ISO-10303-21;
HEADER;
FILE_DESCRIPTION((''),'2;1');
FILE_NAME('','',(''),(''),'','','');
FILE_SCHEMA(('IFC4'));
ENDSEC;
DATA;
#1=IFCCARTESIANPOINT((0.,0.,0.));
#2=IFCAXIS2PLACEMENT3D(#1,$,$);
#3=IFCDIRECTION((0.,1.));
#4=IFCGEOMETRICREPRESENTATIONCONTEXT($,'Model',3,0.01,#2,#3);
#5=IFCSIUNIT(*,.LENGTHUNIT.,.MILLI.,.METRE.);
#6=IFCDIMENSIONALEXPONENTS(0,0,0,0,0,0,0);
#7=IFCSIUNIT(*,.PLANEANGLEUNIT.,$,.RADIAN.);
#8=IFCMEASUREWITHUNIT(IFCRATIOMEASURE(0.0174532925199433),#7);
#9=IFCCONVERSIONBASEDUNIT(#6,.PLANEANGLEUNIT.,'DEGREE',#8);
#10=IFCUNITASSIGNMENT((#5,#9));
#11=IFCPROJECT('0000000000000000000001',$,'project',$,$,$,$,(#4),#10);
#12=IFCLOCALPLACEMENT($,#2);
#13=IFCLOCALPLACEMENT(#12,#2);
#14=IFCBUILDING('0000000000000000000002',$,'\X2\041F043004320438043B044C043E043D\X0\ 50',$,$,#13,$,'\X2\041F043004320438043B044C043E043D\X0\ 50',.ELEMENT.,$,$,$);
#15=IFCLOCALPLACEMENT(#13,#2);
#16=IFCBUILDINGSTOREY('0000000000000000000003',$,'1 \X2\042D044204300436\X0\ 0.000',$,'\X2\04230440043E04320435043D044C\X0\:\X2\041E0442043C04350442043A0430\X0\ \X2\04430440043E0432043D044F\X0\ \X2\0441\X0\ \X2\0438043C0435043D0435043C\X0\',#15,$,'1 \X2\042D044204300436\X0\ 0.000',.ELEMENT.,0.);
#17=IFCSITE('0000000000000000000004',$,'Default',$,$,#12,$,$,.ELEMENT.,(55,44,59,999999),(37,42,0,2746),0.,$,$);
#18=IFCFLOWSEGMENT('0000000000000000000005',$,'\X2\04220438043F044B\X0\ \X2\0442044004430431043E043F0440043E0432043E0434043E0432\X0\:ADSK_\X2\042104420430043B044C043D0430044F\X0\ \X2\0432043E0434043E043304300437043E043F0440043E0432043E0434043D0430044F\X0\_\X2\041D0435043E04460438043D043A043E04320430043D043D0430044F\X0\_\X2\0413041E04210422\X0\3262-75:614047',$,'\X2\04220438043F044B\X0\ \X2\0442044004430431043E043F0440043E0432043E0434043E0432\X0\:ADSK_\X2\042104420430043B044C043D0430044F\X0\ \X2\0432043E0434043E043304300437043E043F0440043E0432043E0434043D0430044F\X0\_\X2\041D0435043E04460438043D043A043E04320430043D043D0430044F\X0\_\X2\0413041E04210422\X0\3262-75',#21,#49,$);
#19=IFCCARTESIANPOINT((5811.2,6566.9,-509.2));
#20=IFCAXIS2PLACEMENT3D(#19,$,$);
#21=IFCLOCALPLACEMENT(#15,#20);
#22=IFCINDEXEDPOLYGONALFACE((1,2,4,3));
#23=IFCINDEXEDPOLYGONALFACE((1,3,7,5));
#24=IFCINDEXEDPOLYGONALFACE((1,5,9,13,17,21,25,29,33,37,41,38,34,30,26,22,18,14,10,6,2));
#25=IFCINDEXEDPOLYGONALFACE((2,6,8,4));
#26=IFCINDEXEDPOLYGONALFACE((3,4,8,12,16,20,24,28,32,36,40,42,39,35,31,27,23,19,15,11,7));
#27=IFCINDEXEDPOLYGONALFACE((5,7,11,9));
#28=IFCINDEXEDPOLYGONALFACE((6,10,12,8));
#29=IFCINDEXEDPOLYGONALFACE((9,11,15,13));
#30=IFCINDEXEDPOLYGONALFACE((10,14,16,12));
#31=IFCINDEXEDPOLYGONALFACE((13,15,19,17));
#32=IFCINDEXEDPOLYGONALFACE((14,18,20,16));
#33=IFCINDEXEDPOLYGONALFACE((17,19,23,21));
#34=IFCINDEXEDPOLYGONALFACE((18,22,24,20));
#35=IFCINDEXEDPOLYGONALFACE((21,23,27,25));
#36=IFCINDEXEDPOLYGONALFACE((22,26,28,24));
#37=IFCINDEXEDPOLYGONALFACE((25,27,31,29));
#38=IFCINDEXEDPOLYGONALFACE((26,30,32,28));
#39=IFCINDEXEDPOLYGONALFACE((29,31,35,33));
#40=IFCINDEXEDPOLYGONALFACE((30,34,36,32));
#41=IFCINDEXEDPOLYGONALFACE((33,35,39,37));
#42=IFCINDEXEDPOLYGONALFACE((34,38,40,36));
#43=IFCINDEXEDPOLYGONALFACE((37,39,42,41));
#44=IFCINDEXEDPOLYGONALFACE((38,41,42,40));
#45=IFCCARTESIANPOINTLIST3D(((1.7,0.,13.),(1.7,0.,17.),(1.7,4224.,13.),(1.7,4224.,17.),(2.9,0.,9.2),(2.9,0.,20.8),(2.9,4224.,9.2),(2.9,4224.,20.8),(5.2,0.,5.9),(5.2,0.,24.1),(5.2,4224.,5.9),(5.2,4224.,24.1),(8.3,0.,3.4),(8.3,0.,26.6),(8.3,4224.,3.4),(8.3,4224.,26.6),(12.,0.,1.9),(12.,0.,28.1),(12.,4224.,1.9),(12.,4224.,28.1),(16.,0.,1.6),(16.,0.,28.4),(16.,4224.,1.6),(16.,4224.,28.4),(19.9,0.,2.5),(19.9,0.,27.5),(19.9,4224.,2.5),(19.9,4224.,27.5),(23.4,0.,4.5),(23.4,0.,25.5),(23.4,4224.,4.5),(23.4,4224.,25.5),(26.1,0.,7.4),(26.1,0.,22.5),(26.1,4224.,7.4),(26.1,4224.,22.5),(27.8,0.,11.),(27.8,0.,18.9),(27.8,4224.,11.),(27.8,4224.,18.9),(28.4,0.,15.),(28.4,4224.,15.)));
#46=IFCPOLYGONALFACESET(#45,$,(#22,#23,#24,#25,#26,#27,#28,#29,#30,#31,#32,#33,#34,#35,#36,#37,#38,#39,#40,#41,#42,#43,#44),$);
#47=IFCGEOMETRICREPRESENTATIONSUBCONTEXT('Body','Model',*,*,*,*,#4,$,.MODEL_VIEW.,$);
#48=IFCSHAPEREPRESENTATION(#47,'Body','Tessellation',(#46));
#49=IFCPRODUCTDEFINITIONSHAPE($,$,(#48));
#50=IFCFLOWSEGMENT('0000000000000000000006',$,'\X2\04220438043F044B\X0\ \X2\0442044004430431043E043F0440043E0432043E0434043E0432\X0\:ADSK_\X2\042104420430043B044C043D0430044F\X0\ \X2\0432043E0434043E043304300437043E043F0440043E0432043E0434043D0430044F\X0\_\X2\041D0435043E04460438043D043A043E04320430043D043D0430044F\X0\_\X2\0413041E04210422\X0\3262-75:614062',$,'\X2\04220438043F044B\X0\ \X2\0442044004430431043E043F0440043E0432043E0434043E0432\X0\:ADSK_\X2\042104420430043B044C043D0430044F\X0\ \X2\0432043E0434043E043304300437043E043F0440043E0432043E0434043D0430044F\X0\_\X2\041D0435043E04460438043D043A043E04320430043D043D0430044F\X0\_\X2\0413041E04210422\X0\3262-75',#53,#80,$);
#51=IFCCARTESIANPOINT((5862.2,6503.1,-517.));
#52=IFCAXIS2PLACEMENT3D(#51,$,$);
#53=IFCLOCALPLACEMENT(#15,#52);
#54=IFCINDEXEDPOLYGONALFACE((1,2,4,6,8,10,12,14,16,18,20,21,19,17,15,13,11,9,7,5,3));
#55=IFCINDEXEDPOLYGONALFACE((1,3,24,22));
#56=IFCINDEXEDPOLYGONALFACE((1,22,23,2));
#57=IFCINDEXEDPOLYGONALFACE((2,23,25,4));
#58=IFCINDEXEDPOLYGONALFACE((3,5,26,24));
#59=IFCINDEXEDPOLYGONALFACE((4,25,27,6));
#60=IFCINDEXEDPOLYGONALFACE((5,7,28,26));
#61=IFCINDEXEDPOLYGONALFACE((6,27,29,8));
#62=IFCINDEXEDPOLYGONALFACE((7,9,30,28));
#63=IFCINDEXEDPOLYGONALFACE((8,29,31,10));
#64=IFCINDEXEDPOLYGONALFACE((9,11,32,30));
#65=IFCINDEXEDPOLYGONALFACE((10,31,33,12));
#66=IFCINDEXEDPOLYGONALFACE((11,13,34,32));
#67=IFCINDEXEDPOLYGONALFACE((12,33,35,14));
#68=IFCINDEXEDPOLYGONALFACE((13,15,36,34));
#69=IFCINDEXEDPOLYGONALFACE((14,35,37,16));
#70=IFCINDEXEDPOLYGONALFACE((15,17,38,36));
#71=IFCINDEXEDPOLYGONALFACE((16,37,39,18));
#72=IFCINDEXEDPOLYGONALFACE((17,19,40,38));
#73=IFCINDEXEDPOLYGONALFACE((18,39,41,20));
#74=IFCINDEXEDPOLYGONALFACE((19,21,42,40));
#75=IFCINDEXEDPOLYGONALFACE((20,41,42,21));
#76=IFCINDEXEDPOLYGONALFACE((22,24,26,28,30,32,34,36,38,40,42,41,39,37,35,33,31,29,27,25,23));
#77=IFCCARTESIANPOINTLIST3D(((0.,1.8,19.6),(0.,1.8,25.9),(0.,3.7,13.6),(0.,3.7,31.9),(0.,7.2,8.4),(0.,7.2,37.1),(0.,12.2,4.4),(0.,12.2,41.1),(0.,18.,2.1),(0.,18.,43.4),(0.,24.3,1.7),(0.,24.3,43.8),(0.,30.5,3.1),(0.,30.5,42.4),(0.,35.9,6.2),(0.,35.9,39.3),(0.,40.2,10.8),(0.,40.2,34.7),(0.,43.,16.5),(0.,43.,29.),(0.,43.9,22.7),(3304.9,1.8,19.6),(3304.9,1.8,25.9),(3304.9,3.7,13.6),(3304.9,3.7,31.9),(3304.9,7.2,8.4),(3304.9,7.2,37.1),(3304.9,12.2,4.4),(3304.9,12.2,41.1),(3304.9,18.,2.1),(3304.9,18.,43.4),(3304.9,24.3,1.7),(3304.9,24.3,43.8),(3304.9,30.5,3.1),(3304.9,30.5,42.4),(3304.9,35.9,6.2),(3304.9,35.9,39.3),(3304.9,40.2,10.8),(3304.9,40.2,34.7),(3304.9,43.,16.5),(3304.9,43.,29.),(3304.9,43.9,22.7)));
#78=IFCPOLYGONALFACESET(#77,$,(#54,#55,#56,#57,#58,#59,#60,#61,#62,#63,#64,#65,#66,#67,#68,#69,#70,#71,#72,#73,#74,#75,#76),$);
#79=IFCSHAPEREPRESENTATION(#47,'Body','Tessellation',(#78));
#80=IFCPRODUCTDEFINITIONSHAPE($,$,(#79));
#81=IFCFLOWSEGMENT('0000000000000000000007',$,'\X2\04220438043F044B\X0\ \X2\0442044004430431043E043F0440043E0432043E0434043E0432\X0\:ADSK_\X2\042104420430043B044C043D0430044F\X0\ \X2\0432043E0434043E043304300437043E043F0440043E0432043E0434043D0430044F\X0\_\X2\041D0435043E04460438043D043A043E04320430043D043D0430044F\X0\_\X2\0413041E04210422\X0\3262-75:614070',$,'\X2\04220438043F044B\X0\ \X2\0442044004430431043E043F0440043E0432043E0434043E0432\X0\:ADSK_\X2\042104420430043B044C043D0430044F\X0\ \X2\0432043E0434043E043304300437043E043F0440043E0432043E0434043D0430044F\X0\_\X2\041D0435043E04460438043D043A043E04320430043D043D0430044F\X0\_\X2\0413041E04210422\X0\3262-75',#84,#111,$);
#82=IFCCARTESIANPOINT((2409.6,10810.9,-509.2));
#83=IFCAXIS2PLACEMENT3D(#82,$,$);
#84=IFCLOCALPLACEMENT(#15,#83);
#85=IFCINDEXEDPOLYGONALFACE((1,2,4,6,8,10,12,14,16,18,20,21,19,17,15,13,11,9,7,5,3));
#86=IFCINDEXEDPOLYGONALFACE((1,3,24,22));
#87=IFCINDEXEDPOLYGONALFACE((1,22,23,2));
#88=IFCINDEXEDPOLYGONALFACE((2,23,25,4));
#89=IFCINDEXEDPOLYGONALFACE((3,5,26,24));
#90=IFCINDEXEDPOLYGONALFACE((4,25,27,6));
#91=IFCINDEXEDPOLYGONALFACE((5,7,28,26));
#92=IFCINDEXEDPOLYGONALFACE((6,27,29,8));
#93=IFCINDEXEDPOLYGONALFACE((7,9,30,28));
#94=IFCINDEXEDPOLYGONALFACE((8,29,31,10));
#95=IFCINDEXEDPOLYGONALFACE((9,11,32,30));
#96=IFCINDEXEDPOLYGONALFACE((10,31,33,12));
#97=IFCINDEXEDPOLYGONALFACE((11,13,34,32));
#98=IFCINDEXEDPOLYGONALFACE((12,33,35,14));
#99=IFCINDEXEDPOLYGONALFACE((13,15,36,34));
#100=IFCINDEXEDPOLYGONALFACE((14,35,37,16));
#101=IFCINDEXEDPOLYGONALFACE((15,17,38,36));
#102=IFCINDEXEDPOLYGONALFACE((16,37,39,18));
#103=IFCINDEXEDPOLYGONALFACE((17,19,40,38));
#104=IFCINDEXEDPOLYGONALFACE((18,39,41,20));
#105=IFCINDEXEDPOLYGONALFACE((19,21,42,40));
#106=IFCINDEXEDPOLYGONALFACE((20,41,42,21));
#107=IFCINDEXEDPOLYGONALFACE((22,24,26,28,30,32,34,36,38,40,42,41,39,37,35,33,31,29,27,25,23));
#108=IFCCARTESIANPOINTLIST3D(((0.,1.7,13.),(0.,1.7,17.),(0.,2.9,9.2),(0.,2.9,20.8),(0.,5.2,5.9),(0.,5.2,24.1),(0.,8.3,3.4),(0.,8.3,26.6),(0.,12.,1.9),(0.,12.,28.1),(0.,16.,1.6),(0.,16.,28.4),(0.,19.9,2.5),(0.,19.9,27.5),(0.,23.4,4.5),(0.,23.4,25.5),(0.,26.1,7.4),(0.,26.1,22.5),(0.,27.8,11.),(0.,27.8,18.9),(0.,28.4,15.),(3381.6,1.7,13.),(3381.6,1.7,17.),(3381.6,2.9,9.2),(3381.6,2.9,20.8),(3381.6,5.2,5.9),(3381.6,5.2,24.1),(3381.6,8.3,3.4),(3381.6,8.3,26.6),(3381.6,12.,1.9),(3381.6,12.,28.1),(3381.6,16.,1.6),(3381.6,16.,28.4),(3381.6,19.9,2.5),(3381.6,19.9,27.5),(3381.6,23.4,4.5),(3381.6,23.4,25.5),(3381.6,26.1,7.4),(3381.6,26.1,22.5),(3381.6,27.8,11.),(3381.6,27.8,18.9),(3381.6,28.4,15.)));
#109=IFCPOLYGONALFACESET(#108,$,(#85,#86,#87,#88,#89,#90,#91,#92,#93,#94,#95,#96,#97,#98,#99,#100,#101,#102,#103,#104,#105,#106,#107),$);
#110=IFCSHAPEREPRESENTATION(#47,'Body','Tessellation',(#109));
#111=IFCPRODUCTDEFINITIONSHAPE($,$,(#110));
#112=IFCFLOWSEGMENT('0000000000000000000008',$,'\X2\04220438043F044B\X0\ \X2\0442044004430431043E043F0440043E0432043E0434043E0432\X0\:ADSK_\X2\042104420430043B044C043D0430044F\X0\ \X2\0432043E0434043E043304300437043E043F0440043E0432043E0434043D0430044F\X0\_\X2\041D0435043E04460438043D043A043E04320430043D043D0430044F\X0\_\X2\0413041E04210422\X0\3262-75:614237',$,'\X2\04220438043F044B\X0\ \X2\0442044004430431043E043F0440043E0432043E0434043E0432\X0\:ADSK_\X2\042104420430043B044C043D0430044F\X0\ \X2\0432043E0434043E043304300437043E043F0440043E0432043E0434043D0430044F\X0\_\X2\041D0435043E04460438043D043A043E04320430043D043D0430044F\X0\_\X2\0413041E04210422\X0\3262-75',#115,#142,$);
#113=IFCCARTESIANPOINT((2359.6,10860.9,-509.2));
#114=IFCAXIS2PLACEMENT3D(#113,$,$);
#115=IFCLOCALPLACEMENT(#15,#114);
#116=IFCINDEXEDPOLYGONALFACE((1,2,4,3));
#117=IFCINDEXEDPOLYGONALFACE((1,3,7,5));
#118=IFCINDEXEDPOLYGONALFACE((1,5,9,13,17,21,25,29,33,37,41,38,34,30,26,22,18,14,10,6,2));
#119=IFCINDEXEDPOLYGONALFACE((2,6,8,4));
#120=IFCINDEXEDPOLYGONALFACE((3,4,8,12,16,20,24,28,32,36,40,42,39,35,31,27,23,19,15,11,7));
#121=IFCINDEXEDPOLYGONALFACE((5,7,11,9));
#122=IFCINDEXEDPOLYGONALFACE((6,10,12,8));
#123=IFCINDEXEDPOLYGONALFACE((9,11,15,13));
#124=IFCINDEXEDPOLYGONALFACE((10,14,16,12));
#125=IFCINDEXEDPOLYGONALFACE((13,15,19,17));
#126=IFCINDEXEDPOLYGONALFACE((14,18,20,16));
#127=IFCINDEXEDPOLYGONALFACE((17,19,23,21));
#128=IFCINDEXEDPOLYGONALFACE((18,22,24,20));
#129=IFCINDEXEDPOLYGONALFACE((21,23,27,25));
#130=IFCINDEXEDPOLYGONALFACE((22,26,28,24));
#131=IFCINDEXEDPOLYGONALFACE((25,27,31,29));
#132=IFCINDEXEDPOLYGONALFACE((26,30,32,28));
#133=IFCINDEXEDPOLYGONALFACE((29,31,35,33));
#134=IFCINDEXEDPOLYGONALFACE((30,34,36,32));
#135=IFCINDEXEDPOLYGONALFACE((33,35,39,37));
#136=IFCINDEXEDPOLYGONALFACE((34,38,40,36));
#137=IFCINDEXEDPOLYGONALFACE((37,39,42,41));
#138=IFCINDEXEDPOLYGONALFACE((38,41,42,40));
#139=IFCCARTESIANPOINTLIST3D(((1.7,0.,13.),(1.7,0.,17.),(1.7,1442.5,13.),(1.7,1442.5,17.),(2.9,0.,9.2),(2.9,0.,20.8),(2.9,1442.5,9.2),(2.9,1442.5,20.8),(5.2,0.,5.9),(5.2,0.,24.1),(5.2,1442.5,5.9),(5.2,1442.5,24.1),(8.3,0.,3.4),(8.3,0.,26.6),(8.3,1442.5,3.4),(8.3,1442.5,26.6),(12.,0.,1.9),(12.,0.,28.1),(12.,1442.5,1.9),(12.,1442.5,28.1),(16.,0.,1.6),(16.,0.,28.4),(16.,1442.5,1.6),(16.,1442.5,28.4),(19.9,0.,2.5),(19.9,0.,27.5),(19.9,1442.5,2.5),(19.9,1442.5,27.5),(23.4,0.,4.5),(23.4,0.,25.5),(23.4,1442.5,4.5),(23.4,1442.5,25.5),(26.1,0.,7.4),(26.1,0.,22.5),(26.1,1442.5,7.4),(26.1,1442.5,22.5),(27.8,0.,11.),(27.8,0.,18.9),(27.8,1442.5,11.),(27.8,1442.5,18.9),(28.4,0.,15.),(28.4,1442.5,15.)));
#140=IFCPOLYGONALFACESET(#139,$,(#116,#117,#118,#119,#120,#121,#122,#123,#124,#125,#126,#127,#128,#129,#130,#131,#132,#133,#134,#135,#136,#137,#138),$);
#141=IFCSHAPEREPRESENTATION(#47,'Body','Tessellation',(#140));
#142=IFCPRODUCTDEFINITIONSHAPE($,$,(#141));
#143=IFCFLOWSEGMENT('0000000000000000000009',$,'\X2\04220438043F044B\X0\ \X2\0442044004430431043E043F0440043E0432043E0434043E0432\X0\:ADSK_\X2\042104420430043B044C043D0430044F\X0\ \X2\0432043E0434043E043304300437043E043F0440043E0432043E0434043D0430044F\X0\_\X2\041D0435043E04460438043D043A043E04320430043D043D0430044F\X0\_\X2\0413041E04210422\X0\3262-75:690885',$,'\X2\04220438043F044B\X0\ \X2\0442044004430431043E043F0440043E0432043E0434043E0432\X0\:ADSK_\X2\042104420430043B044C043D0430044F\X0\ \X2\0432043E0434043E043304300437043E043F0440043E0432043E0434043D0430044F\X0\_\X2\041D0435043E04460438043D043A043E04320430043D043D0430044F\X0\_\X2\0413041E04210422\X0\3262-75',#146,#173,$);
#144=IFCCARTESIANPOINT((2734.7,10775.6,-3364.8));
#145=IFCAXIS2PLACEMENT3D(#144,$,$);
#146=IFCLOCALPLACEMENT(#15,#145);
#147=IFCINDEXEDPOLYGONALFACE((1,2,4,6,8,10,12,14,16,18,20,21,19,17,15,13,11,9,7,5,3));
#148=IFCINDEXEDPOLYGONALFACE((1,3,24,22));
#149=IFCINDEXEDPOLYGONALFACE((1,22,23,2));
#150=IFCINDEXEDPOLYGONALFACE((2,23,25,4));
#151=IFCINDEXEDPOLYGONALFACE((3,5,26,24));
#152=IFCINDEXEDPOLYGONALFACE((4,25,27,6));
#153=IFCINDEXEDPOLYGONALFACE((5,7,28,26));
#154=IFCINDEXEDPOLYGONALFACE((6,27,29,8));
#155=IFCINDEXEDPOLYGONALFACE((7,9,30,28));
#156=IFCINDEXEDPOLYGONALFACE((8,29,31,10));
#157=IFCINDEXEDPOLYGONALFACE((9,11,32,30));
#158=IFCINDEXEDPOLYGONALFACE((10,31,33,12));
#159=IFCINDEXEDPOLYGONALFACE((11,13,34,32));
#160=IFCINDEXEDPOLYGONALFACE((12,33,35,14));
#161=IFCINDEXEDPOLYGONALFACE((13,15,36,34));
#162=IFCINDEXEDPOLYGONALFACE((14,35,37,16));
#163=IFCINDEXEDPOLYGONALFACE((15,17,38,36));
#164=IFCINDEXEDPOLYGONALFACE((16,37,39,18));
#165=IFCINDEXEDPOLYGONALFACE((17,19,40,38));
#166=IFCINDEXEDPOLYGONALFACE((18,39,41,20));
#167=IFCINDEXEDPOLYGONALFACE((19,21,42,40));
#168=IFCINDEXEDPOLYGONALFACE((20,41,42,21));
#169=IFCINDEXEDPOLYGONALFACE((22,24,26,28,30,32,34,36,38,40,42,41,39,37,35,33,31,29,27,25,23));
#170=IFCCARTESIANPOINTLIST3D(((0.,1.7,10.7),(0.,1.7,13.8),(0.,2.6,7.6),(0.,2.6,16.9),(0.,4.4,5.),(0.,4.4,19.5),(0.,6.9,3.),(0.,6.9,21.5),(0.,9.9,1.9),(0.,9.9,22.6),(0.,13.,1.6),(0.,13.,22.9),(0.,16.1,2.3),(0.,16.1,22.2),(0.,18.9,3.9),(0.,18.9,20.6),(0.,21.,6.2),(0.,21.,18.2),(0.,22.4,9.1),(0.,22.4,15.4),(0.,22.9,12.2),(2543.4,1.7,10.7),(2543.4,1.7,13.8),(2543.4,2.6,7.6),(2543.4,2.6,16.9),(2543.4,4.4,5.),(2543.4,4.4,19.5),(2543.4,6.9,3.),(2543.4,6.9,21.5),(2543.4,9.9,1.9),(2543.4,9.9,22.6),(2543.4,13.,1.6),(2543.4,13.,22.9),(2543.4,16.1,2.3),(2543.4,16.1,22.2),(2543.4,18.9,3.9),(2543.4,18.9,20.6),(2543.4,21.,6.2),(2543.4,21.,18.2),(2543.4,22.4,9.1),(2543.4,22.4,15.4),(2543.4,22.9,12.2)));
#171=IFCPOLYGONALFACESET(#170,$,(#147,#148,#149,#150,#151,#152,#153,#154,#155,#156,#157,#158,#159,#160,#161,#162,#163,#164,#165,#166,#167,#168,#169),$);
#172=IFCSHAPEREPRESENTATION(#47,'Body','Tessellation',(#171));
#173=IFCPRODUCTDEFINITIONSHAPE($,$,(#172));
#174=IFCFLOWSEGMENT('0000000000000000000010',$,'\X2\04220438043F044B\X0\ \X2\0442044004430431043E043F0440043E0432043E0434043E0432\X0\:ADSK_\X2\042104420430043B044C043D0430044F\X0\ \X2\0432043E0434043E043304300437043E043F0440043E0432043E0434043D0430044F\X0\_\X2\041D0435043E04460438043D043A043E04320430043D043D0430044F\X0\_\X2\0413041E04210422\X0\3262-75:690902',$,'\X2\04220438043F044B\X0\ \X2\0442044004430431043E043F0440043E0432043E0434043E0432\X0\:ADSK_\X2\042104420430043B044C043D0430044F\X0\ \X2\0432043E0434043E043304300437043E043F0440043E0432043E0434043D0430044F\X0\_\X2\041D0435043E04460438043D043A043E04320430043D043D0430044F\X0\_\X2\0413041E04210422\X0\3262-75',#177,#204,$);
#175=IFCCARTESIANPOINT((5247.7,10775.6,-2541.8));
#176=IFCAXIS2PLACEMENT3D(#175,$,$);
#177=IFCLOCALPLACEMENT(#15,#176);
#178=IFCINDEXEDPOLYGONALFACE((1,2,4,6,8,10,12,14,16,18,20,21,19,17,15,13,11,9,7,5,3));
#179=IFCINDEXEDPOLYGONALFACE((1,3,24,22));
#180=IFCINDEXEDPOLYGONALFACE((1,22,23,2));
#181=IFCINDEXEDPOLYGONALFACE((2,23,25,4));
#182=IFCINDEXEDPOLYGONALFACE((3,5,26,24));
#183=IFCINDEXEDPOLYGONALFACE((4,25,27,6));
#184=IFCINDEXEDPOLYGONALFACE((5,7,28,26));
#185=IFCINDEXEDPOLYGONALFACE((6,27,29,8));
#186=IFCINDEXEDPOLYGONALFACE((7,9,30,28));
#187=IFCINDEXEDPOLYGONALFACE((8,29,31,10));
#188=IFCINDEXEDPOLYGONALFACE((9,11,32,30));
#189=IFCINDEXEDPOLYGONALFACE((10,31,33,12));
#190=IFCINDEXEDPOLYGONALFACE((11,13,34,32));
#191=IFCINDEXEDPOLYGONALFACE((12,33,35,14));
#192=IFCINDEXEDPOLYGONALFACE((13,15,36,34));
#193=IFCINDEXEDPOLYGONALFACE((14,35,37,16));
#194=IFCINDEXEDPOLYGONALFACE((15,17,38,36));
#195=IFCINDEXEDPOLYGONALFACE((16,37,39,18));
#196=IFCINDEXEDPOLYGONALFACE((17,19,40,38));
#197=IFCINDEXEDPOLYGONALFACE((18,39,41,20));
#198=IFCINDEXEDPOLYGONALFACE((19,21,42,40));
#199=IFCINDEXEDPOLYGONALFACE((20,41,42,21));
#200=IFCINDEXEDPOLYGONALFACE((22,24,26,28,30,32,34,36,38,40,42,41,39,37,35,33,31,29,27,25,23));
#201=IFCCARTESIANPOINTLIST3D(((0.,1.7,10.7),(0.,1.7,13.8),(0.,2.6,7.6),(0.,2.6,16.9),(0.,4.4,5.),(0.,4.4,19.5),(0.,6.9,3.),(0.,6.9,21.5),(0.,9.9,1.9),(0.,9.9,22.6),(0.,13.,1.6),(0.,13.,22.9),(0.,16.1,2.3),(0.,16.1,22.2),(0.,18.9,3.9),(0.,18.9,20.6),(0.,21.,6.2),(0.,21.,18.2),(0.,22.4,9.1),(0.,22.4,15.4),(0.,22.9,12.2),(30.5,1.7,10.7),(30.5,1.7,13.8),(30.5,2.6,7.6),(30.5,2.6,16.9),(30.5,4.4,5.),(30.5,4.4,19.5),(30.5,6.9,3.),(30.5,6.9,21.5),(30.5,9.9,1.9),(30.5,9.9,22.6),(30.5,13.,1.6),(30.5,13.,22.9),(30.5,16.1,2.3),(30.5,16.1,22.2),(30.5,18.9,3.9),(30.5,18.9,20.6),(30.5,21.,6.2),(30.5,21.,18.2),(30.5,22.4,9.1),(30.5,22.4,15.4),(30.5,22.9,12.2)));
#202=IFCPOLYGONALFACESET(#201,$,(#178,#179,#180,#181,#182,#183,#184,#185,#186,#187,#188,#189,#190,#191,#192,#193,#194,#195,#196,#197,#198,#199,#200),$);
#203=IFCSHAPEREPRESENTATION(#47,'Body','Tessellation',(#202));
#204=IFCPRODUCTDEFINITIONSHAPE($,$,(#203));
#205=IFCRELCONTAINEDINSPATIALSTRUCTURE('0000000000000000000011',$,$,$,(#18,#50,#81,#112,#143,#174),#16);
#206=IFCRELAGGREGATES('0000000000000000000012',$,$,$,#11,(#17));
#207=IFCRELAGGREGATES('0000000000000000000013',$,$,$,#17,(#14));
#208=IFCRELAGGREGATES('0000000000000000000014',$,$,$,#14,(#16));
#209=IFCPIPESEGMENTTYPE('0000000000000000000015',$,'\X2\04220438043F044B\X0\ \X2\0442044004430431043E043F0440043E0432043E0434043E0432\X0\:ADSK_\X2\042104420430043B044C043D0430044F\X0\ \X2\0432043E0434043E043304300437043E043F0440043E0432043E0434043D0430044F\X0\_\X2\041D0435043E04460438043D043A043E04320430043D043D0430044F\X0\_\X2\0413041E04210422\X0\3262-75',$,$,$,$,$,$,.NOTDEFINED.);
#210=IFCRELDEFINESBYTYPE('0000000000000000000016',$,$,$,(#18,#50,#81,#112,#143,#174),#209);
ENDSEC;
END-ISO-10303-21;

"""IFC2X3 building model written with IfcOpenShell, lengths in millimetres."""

from ifc_helpers import new_model, entity, si_unit, converted_unit, direction, frame, frame_2d, origin, origin_2d_with_axis, place, context, subcontext, project, spatial, circle, extrude, type_object, element, save


model = new_model("IFC2X3")

# Units and contexts
model_context = context("Model", 3, precision=0.01, world=origin(), true_north=direction((0.0, 1.0)))
body_context = subcontext(model_context, "Body", "Model", "MODEL_VIEW")
ifc_project = project(units=[si_unit("LENGTHUNIT", "METRE", prefix="MILLI"), converted_unit("PLANEANGLEUNIT", "DEGREE", entity("IfcRatioMeasure", 0.0174532925199433), si_unit("PLANEANGLEUNIT", "RADIAN"), dimensions=[0, 0, 0, 0, 0, 0, 0])], contexts=[model_context])

# Site, building, storey
site_placement = place(None, origin())
site = spatial("IfcSite", under=ifc_project, at=site_placement, Name="Default", CompositionType="ELEMENT", RefLatitude=(55, 44, 59, 999999), RefLongitude=(37, 42, 0, 2746), RefElevation=0.0)
building_placement = place(site_placement, origin())
building = spatial("IfcBuilding", under=site, at=building_placement, Name="Павильон 50", LongName="Павильон 50", CompositionType="ELEMENT")
storey_placement = place(building_placement, origin())
storey = spatial("IfcBuildingStorey", under=building, at=storey_placement, Name="1 Этаж 0.000", ObjectType="Уровень:Отметка уровня с именем", LongName="1 Этаж 0.000", CompositionType="ELEMENT", Elevation=0.0)

# Flow segments
pipe_segment_type = type_object("IfcPipeSegmentType", Name="Типы трубопроводов:ADSK_Стальная водогазопроводная_Неоцинкованная_ГОСТ3262-75", PredefinedType="NOTDEFINED")
flow_segment_1_placement = place(storey_placement, frame((5811.2, 6566.9, -509.2)))
element("IfcFlowSegment", 1, at=flow_segment_1_placement, inside=storey, type_object=pipe_segment_type, Name="Типы трубопроводов:ADSK_Стальная водогазопроводная_Неоцинкованная_ГОСТ3262-75:614047", ObjectType="Типы трубопроводов:ADSK_Стальная водогазопроводная_Неоцинкованная_ГОСТ3262-75", context=body_context, shape_type="SweptSolid", body=[
    extrude(circle(Radius=13.4, at=origin_2d_with_axis()), frame((15.0, 0.0, 15.0), z_axis=(0.0, 1.0, 0.0), x_axis=(1.0, 0.0, 0.0)), (0.0, 0.0, 1.0), 4224.0),
])
flow_segment_2_placement = place(storey_placement, frame((5862.2, 6503.1, -517.0)))
element("IfcFlowSegment", 2, at=flow_segment_2_placement, inside=storey, type_object=pipe_segment_type, Name="Типы трубопроводов:ADSK_Стальная водогазопроводная_Неоцинкованная_ГОСТ3262-75:614062", ObjectType="Типы трубопроводов:ADSK_Стальная водогазопроводная_Неоцинкованная_ГОСТ3262-75", context=body_context, shape_type="SweptSolid", body=[
    extrude(circle(Radius=21.1, at=frame_2d((0.0, 0.0), x_axis=(1.0, 0.0))), frame((0.0, 22.7, 22.7), z_axis=(1.0, 0.0, 0.0), x_axis=(0.0, 1.0, 0.0)), (0.0, 0.0, 1.0), 3304.9),
])
flow_segment_3_placement = place(storey_placement, frame((2409.6, 10810.9, -509.2)))
element("IfcFlowSegment", 3, at=flow_segment_3_placement, inside=storey, type_object=pipe_segment_type, Name="Типы трубопроводов:ADSK_Стальная водогазопроводная_Неоцинкованная_ГОСТ3262-75:614070", ObjectType="Типы трубопроводов:ADSK_Стальная водогазопроводная_Неоцинкованная_ГОСТ3262-75", context=body_context, shape_type="SweptSolid", body=[
    extrude(circle(Radius=13.4, at=frame_2d((0.0, 0.0), x_axis=(1.0, 0.0))), frame((0.0, 15.0, 15.0), z_axis=(1.0, 0.0, 0.0), x_axis=(0.0, 1.0, 0.0)), (0.0, 0.0, 1.0), 3381.6),
])
flow_segment_4_placement = place(storey_placement, frame((2359.6, 10860.9, -509.2)))
element("IfcFlowSegment", 4, at=flow_segment_4_placement, inside=storey, type_object=pipe_segment_type, Name="Типы трубопроводов:ADSK_Стальная водогазопроводная_Неоцинкованная_ГОСТ3262-75:614237", ObjectType="Типы трубопроводов:ADSK_Стальная водогазопроводная_Неоцинкованная_ГОСТ3262-75", context=body_context, shape_type="SweptSolid", body=[
    extrude(circle(Radius=13.4, at=origin_2d_with_axis()), frame((15.0, 0.0, 15.0), z_axis=(0.0, 1.0, 0.0), x_axis=(1.0, 0.0, 0.0)), (0.0, 0.0, 1.0), 1442.5),
])
flow_segment_5_placement = place(storey_placement, frame((2734.7, 10775.6, -3364.8)))
element("IfcFlowSegment", 5, at=flow_segment_5_placement, inside=storey, type_object=pipe_segment_type, Name="Типы трубопроводов:ADSK_Стальная водогазопроводная_Неоцинкованная_ГОСТ3262-75:690885", ObjectType="Типы трубопроводов:ADSK_Стальная водогазопроводная_Неоцинкованная_ГОСТ3262-75", context=body_context, shape_type="SweptSolid", body=[
    extrude(circle(Radius=10.7, at=origin_2d_with_axis()), frame((0.0, 12.2, 12.2), z_axis=(1.0, 0.0, 0.0), x_axis=(0.0, 1.0, 0.0)), (0.0, 0.0, 1.0), 2543.4),
])
flow_segment_6_placement = place(storey_placement, frame((5247.7, 10775.6, -2541.8)))
element("IfcFlowSegment", 6, at=flow_segment_6_placement, inside=storey, type_object=pipe_segment_type, Name="Типы трубопроводов:ADSK_Стальная водогазопроводная_Неоцинкованная_ГОСТ3262-75:690902", ObjectType="Типы трубопроводов:ADSK_Стальная водогазопроводная_Неоцинкованная_ГОСТ3262-75", context=body_context, shape_type="SweptSolid", body=[
    extrude(circle(Radius=10.7, at=origin_2d_with_axis()), frame((0.0, 12.2, 12.2), z_axis=(1.0, 0.0, 0.0), x_axis=(0.0, 1.0, 0.0)), (0.0, 0.0, 1.0), 30.5),
])

save(model, "model.ifc")
